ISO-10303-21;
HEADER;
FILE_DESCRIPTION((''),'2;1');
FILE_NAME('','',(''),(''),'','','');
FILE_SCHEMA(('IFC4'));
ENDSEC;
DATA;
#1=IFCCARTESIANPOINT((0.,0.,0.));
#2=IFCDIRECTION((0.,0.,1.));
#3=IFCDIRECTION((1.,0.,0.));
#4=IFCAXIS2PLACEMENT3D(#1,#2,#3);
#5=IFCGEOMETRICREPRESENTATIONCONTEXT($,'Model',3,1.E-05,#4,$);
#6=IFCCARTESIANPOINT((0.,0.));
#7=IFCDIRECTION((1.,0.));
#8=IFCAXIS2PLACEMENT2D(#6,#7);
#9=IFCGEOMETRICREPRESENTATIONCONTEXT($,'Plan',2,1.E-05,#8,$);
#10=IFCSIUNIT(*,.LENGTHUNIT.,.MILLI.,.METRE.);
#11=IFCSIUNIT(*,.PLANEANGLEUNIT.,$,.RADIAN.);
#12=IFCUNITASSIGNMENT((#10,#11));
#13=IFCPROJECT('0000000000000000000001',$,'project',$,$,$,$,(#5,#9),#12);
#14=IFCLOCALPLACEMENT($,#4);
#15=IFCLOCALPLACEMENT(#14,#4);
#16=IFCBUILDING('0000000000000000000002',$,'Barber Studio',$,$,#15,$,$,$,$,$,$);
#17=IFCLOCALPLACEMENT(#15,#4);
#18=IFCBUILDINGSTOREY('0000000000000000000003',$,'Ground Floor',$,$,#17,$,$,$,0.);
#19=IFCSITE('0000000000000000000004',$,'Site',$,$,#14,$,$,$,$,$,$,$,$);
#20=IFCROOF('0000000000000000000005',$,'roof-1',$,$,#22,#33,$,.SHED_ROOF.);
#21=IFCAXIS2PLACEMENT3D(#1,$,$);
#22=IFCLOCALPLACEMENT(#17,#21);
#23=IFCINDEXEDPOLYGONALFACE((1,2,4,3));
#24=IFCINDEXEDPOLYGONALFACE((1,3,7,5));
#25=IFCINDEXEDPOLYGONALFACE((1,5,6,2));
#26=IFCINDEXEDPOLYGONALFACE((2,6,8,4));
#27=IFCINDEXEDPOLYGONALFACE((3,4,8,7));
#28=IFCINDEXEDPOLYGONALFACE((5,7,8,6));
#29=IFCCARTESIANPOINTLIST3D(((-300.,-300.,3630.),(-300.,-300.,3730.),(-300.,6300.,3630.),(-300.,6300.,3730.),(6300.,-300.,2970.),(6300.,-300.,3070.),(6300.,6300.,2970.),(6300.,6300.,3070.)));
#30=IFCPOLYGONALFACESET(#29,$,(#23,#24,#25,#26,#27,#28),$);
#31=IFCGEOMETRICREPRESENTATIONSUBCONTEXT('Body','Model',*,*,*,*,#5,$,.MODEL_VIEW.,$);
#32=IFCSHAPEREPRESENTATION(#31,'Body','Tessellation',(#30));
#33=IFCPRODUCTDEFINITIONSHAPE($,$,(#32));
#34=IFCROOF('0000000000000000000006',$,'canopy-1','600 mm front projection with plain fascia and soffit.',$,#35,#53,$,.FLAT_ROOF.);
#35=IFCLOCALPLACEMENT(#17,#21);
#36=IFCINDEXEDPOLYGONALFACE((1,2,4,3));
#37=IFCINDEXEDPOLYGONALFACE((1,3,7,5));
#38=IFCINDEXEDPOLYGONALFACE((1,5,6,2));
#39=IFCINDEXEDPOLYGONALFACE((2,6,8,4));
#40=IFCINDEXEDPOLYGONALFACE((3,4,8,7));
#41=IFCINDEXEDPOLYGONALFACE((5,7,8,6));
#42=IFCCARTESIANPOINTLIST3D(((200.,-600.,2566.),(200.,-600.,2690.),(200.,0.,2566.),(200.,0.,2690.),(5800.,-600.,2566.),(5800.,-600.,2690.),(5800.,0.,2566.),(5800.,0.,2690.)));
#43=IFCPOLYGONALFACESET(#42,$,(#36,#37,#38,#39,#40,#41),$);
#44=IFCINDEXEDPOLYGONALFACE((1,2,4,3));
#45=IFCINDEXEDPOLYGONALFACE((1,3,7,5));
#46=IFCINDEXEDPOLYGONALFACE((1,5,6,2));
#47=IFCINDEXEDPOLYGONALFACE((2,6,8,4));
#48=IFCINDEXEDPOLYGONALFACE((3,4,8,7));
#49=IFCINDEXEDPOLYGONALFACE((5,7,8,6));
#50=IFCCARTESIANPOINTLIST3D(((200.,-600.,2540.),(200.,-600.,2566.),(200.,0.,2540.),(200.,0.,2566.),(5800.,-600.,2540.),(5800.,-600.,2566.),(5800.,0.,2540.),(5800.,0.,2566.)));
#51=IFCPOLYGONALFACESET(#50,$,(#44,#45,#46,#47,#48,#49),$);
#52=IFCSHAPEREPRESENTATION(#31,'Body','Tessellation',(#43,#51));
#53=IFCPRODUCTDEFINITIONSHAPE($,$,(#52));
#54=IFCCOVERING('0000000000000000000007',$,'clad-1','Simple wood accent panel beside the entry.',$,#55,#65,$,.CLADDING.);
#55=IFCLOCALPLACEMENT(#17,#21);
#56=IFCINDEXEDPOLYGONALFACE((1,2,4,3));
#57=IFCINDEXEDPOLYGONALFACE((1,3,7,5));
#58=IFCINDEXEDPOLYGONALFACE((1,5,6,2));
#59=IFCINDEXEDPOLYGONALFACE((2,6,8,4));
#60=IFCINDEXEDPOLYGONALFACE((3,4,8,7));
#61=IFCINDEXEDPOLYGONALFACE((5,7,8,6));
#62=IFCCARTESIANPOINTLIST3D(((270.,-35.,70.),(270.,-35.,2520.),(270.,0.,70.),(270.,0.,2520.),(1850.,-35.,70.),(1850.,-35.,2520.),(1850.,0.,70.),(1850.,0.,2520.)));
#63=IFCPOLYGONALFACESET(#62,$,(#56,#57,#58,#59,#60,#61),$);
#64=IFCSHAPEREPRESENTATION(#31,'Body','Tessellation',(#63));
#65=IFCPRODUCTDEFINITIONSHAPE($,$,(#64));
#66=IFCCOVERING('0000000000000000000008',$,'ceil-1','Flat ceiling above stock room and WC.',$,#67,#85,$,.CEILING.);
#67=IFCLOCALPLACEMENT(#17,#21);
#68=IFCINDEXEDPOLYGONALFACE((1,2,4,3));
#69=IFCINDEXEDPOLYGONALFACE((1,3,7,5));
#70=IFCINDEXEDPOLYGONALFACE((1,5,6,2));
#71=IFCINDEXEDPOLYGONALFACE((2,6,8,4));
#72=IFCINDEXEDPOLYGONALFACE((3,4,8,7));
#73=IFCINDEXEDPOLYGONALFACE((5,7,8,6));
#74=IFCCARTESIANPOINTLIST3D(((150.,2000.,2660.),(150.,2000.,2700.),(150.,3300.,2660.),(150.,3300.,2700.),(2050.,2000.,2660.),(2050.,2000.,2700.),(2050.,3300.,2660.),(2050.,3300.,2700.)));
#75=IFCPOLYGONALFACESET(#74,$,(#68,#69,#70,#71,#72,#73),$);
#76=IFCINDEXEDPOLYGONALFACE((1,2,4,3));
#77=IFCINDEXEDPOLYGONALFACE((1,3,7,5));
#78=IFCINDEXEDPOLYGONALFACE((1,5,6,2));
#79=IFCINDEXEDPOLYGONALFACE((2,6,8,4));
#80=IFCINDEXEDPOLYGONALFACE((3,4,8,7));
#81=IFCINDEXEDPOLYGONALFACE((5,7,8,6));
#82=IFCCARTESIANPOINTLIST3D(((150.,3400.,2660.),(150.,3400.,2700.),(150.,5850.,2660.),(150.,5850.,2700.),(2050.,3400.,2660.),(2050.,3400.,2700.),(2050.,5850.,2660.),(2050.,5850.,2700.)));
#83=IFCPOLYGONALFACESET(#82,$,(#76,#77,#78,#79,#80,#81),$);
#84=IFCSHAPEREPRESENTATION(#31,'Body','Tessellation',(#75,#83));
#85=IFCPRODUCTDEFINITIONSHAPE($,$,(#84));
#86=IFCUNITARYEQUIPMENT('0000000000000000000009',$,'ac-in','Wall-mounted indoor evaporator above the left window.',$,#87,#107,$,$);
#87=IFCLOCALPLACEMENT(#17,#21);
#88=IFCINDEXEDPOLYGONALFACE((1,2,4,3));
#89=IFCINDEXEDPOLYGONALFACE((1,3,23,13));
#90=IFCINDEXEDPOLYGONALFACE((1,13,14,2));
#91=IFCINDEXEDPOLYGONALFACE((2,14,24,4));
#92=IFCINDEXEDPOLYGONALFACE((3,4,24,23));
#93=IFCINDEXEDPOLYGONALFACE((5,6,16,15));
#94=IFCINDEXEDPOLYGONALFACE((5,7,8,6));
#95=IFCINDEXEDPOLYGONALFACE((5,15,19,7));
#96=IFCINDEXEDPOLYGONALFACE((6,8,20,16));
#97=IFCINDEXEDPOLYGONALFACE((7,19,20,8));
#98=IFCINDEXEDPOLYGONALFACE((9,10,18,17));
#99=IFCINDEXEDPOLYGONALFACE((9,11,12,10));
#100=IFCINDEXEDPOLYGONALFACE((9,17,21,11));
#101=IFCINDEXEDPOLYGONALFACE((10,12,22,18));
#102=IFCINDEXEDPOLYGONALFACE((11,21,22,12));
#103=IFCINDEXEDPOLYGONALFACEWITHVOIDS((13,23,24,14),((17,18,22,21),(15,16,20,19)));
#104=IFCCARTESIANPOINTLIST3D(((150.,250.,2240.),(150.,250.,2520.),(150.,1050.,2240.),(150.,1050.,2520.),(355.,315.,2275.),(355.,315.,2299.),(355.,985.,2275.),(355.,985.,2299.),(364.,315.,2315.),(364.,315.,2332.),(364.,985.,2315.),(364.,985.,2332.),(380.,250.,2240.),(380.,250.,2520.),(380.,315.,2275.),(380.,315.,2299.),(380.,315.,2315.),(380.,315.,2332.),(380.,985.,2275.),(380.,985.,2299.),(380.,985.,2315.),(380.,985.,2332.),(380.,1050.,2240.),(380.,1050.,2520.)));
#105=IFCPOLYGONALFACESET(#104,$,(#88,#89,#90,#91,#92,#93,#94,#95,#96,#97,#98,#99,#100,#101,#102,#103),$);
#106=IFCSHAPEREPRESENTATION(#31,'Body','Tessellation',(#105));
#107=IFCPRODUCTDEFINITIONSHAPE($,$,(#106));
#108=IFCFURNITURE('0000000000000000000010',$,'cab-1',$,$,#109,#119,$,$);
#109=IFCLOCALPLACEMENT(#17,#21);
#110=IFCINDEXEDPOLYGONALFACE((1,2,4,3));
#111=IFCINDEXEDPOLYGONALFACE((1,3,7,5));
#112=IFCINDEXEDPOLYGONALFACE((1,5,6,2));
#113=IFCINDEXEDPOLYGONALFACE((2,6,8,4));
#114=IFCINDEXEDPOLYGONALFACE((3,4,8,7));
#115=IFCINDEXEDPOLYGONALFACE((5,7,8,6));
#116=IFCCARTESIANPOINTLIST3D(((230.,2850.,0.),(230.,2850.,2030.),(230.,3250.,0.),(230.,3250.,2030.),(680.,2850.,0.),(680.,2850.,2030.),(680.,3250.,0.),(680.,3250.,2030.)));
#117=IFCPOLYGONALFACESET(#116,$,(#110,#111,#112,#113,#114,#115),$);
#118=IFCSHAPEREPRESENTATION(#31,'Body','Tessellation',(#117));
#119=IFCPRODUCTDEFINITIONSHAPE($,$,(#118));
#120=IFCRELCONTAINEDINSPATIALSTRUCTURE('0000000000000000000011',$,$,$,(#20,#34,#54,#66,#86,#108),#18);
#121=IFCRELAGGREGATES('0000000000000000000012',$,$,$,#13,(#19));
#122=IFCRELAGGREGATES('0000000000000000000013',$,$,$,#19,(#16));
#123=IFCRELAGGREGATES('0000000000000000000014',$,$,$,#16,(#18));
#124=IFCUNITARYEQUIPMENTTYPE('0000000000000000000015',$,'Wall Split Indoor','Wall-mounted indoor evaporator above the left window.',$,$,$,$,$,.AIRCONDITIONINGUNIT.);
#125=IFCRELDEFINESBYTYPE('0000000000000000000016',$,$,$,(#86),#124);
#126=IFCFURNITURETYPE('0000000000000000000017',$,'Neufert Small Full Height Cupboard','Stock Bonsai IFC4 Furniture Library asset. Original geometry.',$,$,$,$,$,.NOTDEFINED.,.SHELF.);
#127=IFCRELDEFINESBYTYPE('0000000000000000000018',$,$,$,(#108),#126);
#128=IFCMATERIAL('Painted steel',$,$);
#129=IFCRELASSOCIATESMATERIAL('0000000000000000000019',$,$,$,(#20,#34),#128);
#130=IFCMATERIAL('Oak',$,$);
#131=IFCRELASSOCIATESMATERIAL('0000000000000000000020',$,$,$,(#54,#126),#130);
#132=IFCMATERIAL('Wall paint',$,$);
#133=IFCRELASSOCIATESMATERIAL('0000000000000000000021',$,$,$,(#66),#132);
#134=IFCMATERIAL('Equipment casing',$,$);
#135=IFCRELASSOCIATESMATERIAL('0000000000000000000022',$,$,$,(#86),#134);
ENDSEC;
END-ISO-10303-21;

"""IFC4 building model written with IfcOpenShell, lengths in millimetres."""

from ifc_helpers import new_model, entity, si_unit, frame, origin_with_axes, origin_2d_with_axis, place, context, subcontext, project, spatial, line, indexed_curve, outline, extrude, boolean, shape, source, transform, mapped, material, type_object, type_shapes, element, save


model = new_model("IFC4")

# Units and contexts
model_context = context("Model", 3, precision=1e-05, world=origin_with_axes())
plan_context = context("Plan", 2, precision=1e-05, world=origin_2d_with_axis())
body_context_1 = subcontext(model_context, "Body", "Model", "MODEL_VIEW")
body_context_2 = subcontext(plan_context, "Body", "Plan", "PLAN_VIEW")
ifc_project = project(units=[si_unit("LENGTHUNIT", "METRE", prefix="MILLI"), si_unit("PLANEANGLEUNIT", "RADIAN")], contexts=[model_context, plan_context])

# Site, building, storey
site_placement = place(None, origin_with_axes())
site = spatial("IfcSite", under=ifc_project, at=site_placement, Name="Site")
building_placement = place(site_placement, origin_with_axes())
building = spatial("IfcBuilding", under=site, at=building_placement, Name="Barber Studio")
storey_placement = place(building_placement, origin_with_axes())
storey = spatial("IfcBuildingStorey", under=building, at=storey_placement, Name="Ground Floor", Elevation=0.0)

# Shared definitions
ifc_material_1 = material(Name="Painted steel")

# Shared definitions
ifc_material_2 = material(Name="Wall paint")

# Roofs
roof_1_placement = place(storey_placement, frame((-300.0, -300.0, 3630.0), z_axis=(0.0, 0.0, 1.0), x_axis=(1.0, 0.0, 0.0)))
element("IfcRoof", 1, at=roof_1_placement, inside=storey, material=ifc_material_1, Name="roof-1", PredefinedType="SHED_ROOF", context=body_context_1, shape_type="SweptSolid", body=[
    extrude(outline(indexed_curve([(0.0, 0.0), (6600.0, -660.0), (6600.0, -560.0), (0.0, 100.0)], segments=[line(1, 2, 3, 4, 1)])), frame((0.0, 0.0, 0.0), z_axis=(0.0, -1.0, 0.0), x_axis=(1.0, 0.0, 0.0)), (0.0, 0.0, -1.0), 6600.0),
])
roof_2_placement = place(storey_placement, frame((200.0, -600.0, 2540.0), z_axis=(0.0, 0.0, 1.0), x_axis=(1.0, 0.0, 0.0)))
element("IfcRoof", 2, at=roof_2_placement, inside=storey, material=ifc_material_1, Name="canopy-1", Description="600 mm front projection with plain fascia and soffit.", PredefinedType="FLAT_ROOF", context=body_context_1, shape_type="SweptSolid", body=[
    extrude(outline(indexed_curve([(0.0, 0.0), (5600.0, 0.0), (5600.0, 600.0), (0.0, 600.0)], segments=[line(1, 2, 3, 4, 1)])), frame((0.0, 0.0, 26.0), z_axis=(0.0, 0.0, 1.0), x_axis=(1.0, 0.0, 0.0)), (0.0, 0.0, 1.0), 124.0),
    extrude(outline(indexed_curve([(0.0, 0.0), (5600.0, 0.0), (5600.0, 600.0), (0.0, 600.0)], segments=[line(1, 2, 3, 4, 1)])), origin_with_axes(), (0.0, 0.0, 1.0), 26.0),
])

# Coverings
ifc_material_3 = material(Name="Oak")
covering_1_placement = place(storey_placement, frame((270.0, -35.0, 70.0), z_axis=(0.0, 0.0, 1.0), x_axis=(1.0, 0.0, 0.0)))
element("IfcCovering", 3, at=covering_1_placement, inside=storey, material=ifc_material_3, Name="clad-1", Description="Simple wood accent panel beside the entry.", PredefinedType="CLADDING", context=body_context_1, shape_type="SweptSolid", body=[
    extrude(outline(indexed_curve([(0.0, 0.0), (1580.0, 0.0), (1580.0, 35.0), (0.0, 35.0)], segments=[line(1, 2, 3, 4, 1)])), origin_with_axes(), (0.0, 0.0, 1.0), 2450.0),
])
covering_2_placement = place(storey_placement, frame((150.0, 2000.0, 2660.0), z_axis=(0.0, 0.0, 1.0), x_axis=(1.0, 0.0, 0.0)))
element("IfcCovering", 4, at=covering_2_placement, inside=storey, material=ifc_material_2, Name="ceil-1", Description="Flat ceiling above stock room and WC.", PredefinedType="CEILING", context=body_context_1, shape_type="SweptSolid", body=[
    extrude(outline(indexed_curve([(0.0, 0.0), (1900.0, 0.0), (1900.0, 1300.0), (0.0, 1300.0)], segments=[line(1, 2, 3, 4, 1)])), origin_with_axes(), (0.0, 0.0, 1.0), 40.0),
    extrude(outline(indexed_curve([(0.0, 0.0), (1900.0, 0.0), (1900.0, 2450.0), (0.0, 2450.0)], segments=[line(1, 2, 3, 4, 1)])), frame((0.0, 1400.0, 0.0), z_axis=(0.0, 0.0, 1.0), x_axis=(1.0, 0.0, 0.0)), (0.0, 0.0, 1.0), 40.0),
])

# Unitary equipment
ifc_material_4 = material(Name="Equipment casing")
unitary_equipment_type_1 = type_object("IfcUnitaryEquipmentType", Name="Wall Split Indoor", Description="Wall-mounted indoor evaporator above the left window.", PredefinedType="AIRCONDITIONINGUNIT")
unitary_equipment_1_placement = place(storey_placement, frame((150.0, 250.0, 2240.0), z_axis=(0.0, 0.0, 1.0), x_axis=(1.0, 0.0, 0.0)))
element("IfcUnitaryEquipment", 5, at=unitary_equipment_1_placement, inside=storey, type_object=unitary_equipment_type_1, material=ifc_material_4, Name="ac-in", Description="Wall-mounted indoor evaporator above the left window.", context=body_context_1, shape_type="CSG", body=[
    boolean("DIFFERENCE", boolean("DIFFERENCE", extrude(outline(indexed_curve([(0.0, 0.0), (230.0, 0.0), (230.0, 800.0), (0.0, 800.0)], segments=[line(1, 2, 3, 4, 1)])), origin_with_axes(), (0.0, 0.0, 1.0), 280.0), extrude(outline(indexed_curve([(0.0, 0.0), (34.0, 0.0), (34.0, 670.0), (0.0, 670.0)], segments=[line(1, 2, 3, 4, 1)])), frame((205.0, 65.0, 35.0), z_axis=(0.0, 0.0, 1.0), x_axis=(1.0, 0.0, 0.0)), (0.0, 0.0, 1.0), 24.0)), extrude(outline(indexed_curve([(0.0, 0.0), (25.0, 0.0), (25.0, 670.0), (0.0, 670.0)], segments=[line(1, 2, 3, 4, 1)])), frame((214.0, 65.0, 75.0), z_axis=(0.0, 0.0, 1.0), x_axis=(1.0, 0.0, 0.0)), (0.0, 0.0, 1.0), 17.0)),
])

# Furniture
furniture_type = type_object("IfcFurnitureType", Name="Neufert Small Full Height Cupboard", Description="Stock Bonsai IFC4 Furniture Library asset. Original geometry.", AssemblyPlace="NOTDEFINED", PredefinedType="SHELF", material=ifc_material_3)
shared_shape_1 = source(origin_with_axes(), body_context_1, "Body", "SweptSolid", [
    extrude(outline(indexed_curve([(0.0, 0.0), (450.0, 0.0), (450.0, 400.0), (0.0, 400.0)], segments=[line(1, 2, 3, 4, 1)])), origin_with_axes(), (0.0, 0.0, 1.0), 2030.0),
])
shared_shape_2 = source(origin_with_axes(), body_context_2, "Body", "Curve2D", [
    entity("IfcIndexedPolyCurve", entity("IfcCartesianPointList2D", [[0.0, 0.0], [450.0, 0.0], [450.0, 400.0], [0.0, 400.0]]), [entity("IfcLineIndex", [1, 2, 3, 4, 1])]),
])
type_shapes(furniture_type, [shared_shape_1, shared_shape_2])
furniture_placement = place(storey_placement, frame((230.0, 2850.0, 0.0), z_axis=(0.0, 0.0, 1.0), x_axis=(1.0, 0.0, 0.0)))
element("IfcFurniture", 6, at=furniture_placement, inside=storey, type_object=furniture_type, Name="cab-1", shapes=[
    shape(body_context_1, "Body", "MappedRepresentation", [mapped(shared_shape_1, transform((0.0, 0.0, 0.0), x_axis=(1.0, 0.0, 0.0), y_axis=(0.0, 1.0, 0.0), z_axis=(0.0, 0.0, 1.0), scale=1.0))]),
    shape(body_context_2, "Body", "MappedRepresentation", [mapped(shared_shape_2, transform((0.0, 0.0, 0.0), x_axis=(1.0, 0.0, 0.0), y_axis=(0.0, 1.0, 0.0), z_axis=(0.0, 0.0, 1.0), scale=1.0))]),
])

save(model, "model.ifc")
